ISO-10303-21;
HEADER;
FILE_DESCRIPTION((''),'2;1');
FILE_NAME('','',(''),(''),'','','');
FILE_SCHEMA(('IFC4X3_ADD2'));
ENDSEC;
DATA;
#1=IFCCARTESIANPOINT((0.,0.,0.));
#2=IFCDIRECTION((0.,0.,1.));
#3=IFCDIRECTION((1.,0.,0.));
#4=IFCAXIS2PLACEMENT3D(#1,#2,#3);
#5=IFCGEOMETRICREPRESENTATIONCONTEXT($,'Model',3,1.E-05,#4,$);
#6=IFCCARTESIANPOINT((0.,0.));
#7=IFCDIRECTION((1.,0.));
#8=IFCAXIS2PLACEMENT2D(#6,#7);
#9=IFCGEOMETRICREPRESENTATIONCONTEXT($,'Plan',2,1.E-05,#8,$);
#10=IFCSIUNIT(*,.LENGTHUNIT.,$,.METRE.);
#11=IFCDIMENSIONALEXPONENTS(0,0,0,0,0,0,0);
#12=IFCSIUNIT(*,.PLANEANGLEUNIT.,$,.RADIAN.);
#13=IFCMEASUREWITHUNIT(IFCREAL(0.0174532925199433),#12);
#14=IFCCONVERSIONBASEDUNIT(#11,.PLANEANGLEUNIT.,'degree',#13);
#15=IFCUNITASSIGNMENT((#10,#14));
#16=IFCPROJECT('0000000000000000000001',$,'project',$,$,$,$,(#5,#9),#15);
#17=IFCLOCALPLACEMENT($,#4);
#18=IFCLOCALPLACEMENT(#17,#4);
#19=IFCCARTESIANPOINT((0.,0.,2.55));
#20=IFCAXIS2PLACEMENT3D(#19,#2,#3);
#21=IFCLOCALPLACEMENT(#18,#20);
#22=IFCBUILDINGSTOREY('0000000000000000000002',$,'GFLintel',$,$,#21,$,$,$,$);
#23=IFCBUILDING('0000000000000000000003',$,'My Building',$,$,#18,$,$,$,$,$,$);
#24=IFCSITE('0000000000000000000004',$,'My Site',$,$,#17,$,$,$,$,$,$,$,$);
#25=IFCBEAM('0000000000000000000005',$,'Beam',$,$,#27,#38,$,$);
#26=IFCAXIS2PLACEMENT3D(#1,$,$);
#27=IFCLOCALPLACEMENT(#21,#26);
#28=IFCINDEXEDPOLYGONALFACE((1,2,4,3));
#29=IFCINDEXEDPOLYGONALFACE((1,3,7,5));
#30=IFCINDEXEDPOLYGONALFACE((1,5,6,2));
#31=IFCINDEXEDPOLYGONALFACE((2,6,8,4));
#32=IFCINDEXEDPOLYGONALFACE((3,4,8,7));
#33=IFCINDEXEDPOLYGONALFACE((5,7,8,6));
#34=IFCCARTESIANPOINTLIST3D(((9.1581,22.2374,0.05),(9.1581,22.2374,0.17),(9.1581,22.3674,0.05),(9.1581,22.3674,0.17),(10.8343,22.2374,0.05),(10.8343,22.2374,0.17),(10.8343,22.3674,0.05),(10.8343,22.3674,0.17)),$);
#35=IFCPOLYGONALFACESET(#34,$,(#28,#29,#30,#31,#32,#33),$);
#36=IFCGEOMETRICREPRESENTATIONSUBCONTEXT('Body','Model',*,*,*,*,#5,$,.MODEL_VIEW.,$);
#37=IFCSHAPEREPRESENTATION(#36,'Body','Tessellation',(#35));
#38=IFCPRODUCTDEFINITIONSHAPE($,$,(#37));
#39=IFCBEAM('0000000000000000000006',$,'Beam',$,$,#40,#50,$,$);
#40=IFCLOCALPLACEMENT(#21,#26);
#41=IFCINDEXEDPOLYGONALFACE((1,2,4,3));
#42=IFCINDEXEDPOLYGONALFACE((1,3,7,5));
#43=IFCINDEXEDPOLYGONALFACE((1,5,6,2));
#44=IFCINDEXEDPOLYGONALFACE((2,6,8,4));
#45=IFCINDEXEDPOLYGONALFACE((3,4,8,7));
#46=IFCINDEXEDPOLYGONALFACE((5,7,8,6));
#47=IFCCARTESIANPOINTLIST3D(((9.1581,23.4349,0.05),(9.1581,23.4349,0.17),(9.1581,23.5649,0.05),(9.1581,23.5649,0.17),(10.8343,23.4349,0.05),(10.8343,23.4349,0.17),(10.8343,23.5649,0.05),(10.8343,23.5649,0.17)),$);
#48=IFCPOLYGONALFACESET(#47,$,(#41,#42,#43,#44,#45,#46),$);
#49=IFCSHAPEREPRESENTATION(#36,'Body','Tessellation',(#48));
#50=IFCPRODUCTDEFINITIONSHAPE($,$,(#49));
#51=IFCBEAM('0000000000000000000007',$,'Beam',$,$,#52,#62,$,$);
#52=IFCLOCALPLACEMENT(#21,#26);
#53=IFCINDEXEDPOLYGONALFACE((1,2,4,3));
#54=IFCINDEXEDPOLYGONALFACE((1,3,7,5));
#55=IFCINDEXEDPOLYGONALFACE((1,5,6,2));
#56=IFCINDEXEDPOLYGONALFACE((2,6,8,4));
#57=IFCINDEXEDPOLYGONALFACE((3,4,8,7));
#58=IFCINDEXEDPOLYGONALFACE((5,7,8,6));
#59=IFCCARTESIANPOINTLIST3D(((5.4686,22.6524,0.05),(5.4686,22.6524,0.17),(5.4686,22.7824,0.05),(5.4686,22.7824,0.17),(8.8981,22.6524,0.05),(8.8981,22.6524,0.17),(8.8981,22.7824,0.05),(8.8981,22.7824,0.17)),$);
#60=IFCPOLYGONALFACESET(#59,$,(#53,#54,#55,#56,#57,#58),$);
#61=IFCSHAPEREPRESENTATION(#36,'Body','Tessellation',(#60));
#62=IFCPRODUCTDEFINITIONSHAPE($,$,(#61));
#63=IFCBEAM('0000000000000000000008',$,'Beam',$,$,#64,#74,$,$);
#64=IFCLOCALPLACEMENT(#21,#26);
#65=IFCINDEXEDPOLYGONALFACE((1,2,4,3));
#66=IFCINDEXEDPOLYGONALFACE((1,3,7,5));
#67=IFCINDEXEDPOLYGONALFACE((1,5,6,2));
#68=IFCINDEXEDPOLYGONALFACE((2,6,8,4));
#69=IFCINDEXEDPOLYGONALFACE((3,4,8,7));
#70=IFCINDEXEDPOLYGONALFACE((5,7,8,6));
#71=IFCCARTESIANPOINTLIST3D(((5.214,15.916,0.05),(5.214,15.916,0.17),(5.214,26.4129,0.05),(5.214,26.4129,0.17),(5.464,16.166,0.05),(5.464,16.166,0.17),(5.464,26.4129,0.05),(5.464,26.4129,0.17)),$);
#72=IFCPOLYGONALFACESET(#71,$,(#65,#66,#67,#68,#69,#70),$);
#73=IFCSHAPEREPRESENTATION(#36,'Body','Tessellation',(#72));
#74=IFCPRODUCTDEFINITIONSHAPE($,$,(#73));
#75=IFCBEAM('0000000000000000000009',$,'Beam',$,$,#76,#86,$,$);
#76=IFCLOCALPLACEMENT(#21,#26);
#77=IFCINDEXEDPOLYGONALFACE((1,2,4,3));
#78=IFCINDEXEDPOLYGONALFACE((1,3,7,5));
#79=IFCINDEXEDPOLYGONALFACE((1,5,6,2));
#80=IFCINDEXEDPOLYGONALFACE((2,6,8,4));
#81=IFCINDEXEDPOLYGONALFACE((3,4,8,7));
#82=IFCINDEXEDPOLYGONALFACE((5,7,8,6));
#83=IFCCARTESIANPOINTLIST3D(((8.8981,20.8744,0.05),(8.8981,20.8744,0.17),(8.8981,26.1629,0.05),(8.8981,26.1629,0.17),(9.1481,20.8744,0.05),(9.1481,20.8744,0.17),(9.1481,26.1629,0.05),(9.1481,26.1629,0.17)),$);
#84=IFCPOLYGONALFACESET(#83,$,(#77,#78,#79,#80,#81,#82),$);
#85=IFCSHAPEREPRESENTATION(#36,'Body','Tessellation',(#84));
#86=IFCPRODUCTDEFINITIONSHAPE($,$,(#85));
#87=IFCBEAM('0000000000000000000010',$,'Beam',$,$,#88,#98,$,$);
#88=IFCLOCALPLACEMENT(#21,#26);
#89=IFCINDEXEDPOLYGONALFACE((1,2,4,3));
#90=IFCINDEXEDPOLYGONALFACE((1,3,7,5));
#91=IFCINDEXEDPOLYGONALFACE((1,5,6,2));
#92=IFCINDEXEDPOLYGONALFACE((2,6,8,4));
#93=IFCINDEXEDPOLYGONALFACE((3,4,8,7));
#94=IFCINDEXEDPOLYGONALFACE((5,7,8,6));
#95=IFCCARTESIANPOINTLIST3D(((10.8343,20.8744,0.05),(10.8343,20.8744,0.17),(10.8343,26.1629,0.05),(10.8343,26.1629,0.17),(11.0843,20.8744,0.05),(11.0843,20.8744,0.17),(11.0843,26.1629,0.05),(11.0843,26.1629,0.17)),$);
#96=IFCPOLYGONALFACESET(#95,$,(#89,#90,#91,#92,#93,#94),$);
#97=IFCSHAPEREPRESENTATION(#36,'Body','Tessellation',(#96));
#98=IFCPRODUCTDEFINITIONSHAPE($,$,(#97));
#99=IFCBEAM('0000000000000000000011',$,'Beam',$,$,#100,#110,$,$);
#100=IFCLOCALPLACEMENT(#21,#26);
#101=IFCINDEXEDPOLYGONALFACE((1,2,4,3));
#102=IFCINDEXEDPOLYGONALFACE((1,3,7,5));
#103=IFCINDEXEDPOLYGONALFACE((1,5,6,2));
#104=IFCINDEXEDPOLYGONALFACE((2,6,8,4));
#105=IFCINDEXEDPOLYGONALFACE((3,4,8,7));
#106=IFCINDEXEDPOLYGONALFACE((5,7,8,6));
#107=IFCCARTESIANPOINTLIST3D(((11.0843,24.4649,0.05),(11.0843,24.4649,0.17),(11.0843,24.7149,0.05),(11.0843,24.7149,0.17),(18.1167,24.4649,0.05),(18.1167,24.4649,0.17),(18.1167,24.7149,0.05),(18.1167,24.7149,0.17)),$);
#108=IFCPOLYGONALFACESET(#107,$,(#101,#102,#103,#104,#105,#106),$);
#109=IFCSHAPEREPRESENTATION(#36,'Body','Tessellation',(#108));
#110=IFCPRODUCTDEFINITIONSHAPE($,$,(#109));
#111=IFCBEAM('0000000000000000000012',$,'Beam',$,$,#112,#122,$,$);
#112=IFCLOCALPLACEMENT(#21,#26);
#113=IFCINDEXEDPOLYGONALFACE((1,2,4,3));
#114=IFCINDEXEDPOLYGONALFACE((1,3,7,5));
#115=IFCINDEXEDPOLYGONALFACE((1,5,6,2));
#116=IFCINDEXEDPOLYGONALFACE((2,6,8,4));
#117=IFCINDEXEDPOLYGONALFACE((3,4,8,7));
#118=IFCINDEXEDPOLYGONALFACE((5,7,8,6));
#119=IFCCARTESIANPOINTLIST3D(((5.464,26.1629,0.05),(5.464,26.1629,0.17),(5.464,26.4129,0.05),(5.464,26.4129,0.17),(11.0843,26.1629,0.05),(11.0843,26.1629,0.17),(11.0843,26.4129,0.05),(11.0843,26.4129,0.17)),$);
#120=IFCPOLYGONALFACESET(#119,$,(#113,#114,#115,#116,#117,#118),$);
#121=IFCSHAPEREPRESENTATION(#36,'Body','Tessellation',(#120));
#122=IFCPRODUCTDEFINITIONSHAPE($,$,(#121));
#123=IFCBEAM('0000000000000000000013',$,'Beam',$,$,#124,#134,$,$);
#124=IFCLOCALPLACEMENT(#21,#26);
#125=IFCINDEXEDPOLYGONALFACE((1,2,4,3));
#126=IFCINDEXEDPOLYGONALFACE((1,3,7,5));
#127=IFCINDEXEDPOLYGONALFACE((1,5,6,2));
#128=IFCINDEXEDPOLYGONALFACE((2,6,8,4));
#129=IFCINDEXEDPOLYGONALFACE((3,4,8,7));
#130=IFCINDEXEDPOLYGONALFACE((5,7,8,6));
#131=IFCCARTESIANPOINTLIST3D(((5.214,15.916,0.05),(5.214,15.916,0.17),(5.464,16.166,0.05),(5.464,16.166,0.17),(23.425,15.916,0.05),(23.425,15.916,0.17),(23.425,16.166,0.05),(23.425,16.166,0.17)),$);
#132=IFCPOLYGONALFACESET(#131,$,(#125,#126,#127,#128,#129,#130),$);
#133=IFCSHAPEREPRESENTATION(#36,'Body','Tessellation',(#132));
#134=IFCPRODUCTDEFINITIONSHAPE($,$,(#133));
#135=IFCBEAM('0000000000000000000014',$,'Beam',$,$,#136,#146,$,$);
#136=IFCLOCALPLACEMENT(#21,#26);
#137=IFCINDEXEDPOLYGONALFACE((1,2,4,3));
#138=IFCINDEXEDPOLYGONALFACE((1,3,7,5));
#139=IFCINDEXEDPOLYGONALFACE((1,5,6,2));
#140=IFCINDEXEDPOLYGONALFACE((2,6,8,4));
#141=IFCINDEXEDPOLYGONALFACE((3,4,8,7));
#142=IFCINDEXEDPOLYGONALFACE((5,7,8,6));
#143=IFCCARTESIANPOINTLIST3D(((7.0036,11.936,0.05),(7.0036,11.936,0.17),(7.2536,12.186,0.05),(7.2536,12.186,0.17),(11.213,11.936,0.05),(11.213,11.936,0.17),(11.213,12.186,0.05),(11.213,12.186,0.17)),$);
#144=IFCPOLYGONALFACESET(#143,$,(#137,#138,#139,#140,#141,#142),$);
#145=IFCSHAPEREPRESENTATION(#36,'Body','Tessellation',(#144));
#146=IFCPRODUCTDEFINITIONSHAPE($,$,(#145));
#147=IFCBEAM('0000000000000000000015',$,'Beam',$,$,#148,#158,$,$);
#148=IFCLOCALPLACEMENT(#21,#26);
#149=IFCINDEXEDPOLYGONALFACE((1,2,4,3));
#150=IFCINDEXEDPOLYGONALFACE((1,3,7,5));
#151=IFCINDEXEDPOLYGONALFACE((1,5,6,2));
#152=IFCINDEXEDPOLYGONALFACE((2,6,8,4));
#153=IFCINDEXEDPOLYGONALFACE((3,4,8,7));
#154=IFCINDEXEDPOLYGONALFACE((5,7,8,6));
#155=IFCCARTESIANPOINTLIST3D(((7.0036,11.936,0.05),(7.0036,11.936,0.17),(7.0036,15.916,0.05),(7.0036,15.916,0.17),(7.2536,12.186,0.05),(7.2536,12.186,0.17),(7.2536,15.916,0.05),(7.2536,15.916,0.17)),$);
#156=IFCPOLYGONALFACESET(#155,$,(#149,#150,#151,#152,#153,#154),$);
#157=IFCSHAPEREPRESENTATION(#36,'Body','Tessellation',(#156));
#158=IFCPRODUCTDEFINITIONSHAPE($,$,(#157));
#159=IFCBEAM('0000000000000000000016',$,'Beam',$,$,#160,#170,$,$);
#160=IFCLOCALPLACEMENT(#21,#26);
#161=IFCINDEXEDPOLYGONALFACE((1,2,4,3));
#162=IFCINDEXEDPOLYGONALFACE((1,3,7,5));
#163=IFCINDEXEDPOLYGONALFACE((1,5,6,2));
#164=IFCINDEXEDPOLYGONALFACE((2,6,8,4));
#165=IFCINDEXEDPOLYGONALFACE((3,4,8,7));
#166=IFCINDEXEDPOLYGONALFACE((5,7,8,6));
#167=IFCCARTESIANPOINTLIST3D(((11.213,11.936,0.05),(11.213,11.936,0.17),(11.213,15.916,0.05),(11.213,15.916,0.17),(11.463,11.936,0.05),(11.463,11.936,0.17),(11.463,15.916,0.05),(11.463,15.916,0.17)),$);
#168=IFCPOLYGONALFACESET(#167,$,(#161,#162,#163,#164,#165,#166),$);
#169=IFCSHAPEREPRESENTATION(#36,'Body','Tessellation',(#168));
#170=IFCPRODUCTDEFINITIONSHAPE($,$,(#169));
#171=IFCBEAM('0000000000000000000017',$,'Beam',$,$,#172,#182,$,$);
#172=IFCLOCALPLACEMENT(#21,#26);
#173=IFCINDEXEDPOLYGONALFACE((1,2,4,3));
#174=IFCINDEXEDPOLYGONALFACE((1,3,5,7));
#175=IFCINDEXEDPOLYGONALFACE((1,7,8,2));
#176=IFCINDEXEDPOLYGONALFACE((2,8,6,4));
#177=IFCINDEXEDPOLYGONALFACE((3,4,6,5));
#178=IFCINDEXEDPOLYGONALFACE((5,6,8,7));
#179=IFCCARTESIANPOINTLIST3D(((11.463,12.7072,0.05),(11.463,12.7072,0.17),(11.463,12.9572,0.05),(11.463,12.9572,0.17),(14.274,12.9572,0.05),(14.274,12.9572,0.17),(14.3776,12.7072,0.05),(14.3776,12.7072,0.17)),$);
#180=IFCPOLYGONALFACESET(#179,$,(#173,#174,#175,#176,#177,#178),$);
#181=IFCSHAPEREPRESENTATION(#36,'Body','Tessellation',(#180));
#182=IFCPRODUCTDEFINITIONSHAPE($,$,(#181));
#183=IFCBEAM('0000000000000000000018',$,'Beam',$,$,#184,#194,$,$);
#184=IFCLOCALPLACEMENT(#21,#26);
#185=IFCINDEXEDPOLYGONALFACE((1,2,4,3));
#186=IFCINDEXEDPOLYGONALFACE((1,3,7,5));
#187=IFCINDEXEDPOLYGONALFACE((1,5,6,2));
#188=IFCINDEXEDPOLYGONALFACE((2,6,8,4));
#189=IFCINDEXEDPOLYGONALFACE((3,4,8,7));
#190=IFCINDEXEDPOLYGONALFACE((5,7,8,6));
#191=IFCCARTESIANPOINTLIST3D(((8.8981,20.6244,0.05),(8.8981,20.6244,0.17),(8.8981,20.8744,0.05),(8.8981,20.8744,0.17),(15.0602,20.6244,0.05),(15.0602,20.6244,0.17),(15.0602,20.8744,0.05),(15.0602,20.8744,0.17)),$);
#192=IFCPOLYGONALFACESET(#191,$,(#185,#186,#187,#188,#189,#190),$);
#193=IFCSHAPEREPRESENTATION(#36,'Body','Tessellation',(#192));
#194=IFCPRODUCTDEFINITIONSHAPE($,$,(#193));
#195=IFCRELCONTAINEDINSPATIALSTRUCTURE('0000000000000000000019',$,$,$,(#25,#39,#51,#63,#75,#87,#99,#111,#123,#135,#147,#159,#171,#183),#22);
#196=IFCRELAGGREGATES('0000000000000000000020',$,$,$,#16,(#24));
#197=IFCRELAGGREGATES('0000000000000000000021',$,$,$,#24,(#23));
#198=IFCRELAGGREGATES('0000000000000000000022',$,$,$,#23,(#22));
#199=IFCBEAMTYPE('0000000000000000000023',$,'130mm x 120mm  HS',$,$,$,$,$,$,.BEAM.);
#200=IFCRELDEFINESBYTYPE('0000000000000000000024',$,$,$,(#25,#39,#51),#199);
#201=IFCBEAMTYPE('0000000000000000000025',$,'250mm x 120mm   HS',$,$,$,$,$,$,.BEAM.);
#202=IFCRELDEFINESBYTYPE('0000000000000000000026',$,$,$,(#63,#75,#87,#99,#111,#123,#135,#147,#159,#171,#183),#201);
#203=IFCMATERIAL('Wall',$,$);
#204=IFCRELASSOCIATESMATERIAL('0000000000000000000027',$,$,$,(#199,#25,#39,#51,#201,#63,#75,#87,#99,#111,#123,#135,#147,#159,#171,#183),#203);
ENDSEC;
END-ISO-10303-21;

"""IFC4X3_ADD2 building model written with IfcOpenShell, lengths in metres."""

from ifc_helpers import new_model, entity, si_unit, converted_unit, frame, origin_with_axes, origin_2d_with_axis, place, context, subcontext, project, spatial, rectangle, extrude, clip, halfspace, material, material_profile, profile_set, profile_usage, type_object, element, save


model = new_model("IFC4X3_ADD2")

# Units and contexts
model_context = context("Model", 3, precision=1e-05, world=origin_with_axes())
plan_context = context("Plan", 2, precision=1e-05, world=origin_2d_with_axis())
body_context = subcontext(model_context, "Body", "Model", "MODEL_VIEW")
ifc_project = project(units=[si_unit("LENGTHUNIT", "METRE"), converted_unit("PLANEANGLEUNIT", "degree", entity("IfcReal", 0.0174532925199433), si_unit("PLANEANGLEUNIT", "RADIAN"), dimensions=[0, 0, 0, 0, 0, 0, 0])], contexts=[model_context, plan_context])

# Site, building, storey
site_placement = place(None, origin_with_axes())
site = spatial("IfcSite", under=ifc_project, at=site_placement, Name="My Site")
building_placement = place(site_placement, origin_with_axes())
building = spatial("IfcBuilding", under=site, at=building_placement, Name="My Building")
storey_placement = place(building_placement, frame((0.0, 0.0, 2.55), z_axis=(0.0, 0.0, 1.0), x_axis=(1.0, 0.0, 0.0)))
storey = spatial("IfcBuildingStorey", under=building, at=storey_placement, Name="GFLintel")

# Beams
ifc_material_1 = material(Name="Wall")
ifc_material_profile_1 = material_profile(ifc_material_1, rectangle(XDim=0.13, YDim=0.12))
ifc_profile_set_1 = profile_set([ifc_material_profile_1], Name="concrete")
ifc_profile_usage_1 = profile_usage(ifc_profile_set_1)
beam_type_1 = type_object("IfcBeamType", Name="130mm x 120mm  HS", PredefinedType="BEAM", material=ifc_profile_set_1)
beam_1_placement = place(storey_placement, frame((10.8343, 22.3024, 0.11), z_axis=(-1.0, 0.0, 0.0), x_axis=(0.0, -1.0, 0.0)))
element("IfcBeam", 1, at=beam_1_placement, inside=storey, type_object=beam_type_1, material=ifc_profile_usage_1, Name="Beam", context=body_context, shape_type="SweptSolid", body=[
    extrude(rectangle(XDim=0.13, YDim=0.12), origin_with_axes(), (0.0, 0.0, 1.0), 1.6762),
])
ifc_profile_usage_2 = profile_usage(ifc_profile_set_1)
beam_2_placement = place(storey_placement, frame((10.8343, 23.4999, 0.11), z_axis=(-1.0, 0.0, 0.0), x_axis=(0.0, -1.0, 0.0)))
element("IfcBeam", 2, at=beam_2_placement, inside=storey, type_object=beam_type_1, material=ifc_profile_usage_2, Name="Beam", context=body_context, shape_type="SweptSolid", body=[
    extrude(rectangle(XDim=0.13, YDim=0.12), origin_with_axes(), (0.0, 0.0, 1.0), 1.6762),
])
ifc_profile_usage_3 = profile_usage(ifc_profile_set_1)
beam_3_placement = place(storey_placement, frame((8.8981, 22.7174, 0.11), z_axis=(-1.0, 0.0, 0.0), x_axis=(0.0, -1.0, 0.0)))
element("IfcBeam", 3, at=beam_3_placement, inside=storey, type_object=beam_type_1, material=ifc_profile_usage_3, Name="Beam", context=body_context, shape_type="SweptSolid", body=[
    extrude(rectangle(XDim=0.13, YDim=0.12), origin_with_axes(), (0.0, 0.0, 1.0), 3.4295),
])
ifc_material_profile_2 = material_profile(ifc_material_1, rectangle(XDim=0.25, YDim=0.12))
ifc_profile_set_2 = profile_set([ifc_material_profile_2], Name="concrete")
ifc_profile_usage_4 = profile_usage(ifc_profile_set_2, cardinal=5)
beam_type_2 = type_object("IfcBeamType", Name="250mm x 120mm   HS", PredefinedType="BEAM", material=ifc_profile_set_2)
beam_4_placement = place(storey_placement, frame((5.339, 26.4129, 0.11), z_axis=(0.0, -1.0, 0.0), x_axis=(1.0, 0.0, 0.0)))
element("IfcBeam", 4, at=beam_4_placement, inside=storey, type_object=beam_type_2, material=ifc_profile_usage_4, Name="Beam", context=body_context, shape_type="Clipping", body=[
    clip(extrude(rectangle(XDim=0.25, YDim=0.12), origin_with_axes(), (0.0, 0.0, 1.0), 10.4969), halfspace(frame((-0.125, -2.66, 10.4969), z_axis=(0.707107, 0.0, 0.707107), x_axis=(0.0, -1.0, 0.0)), False)),
])
ifc_profile_usage_5 = profile_usage(ifc_profile_set_2, cardinal=5)
beam_5_placement = place(storey_placement, frame((9.0231, 26.1629, 0.11), z_axis=(0.0, -1.0, 0.0), x_axis=(1.0, 0.0, 0.0)))
element("IfcBeam", 5, at=beam_5_placement, inside=storey, type_object=beam_type_2, material=ifc_profile_usage_5, Name="Beam", context=body_context, shape_type="SweptSolid", body=[
    extrude(rectangle(XDim=0.25, YDim=0.12), origin_with_axes(), (0.0, 0.0, 1.0), 5.2885),
])
ifc_profile_usage_6 = profile_usage(ifc_profile_set_2, cardinal=5)
beam_6_placement = place(storey_placement, frame((10.9593, 26.1629, 0.11), z_axis=(0.0, -1.0, 0.0), x_axis=(1.0, 0.0, 0.0)))
element("IfcBeam", 6, at=beam_6_placement, inside=storey, type_object=beam_type_2, material=ifc_profile_usage_6, Name="Beam", context=body_context, shape_type="SweptSolid", body=[
    extrude(rectangle(XDim=0.25, YDim=0.12), origin_with_axes(), (0.0, 0.0, 1.0), 5.2885),
])
ifc_profile_usage_7 = profile_usage(ifc_profile_set_2, cardinal=5)
beam_7_placement = place(storey_placement, frame((11.0843, 24.5899, 0.11), z_axis=(1.0, 0.0, 0.0), x_axis=(0.0, 1.0, 0.0)))
element("IfcBeam", 7, at=beam_7_placement, inside=storey, type_object=beam_type_2, material=ifc_profile_usage_7, Name="Beam", context=body_context, shape_type="SweptSolid", body=[
    extrude(rectangle(XDim=0.25, YDim=0.12), origin_with_axes(), (0.0, 0.0, 1.0), 7.0324),
])
ifc_profile_usage_8 = profile_usage(ifc_profile_set_2, cardinal=5)
beam_8_placement = place(storey_placement, frame((5.464, 26.2879, 0.11), z_axis=(1.0, 0.0, 0.0), x_axis=(0.0, 1.0, 0.0)))
element("IfcBeam", 8, at=beam_8_placement, inside=storey, type_object=beam_type_2, material=ifc_profile_usage_8, Name="Beam", context=body_context, shape_type="SweptSolid", body=[
    extrude(rectangle(XDim=0.25, YDim=0.12), origin_with_axes(), (0.0, 0.0, 1.0), 5.6203),
])
ifc_profile_usage_9 = profile_usage(ifc_profile_set_2, cardinal=5)
beam_9_placement = place(storey_placement, frame((5.214, 16.041, 0.11), z_axis=(1.0, 0.0, 0.0), x_axis=(0.0, 1.0, 0.0)))
element("IfcBeam", 9, at=beam_9_placement, inside=storey, type_object=beam_type_2, material=ifc_profile_usage_9, Name="Beam", context=body_context, shape_type="Clipping", body=[
    clip(extrude(rectangle(XDim=0.25, YDim=0.12), origin_with_axes(), (0.0, 0.0, 1.0), 18.211), halfspace(frame((-0.125, -2.66, 0.0), z_axis=(0.707107, 0.0, -0.707107), x_axis=(0.0, -1.0, 0.0)), False)),
])
ifc_profile_usage_10 = profile_usage(ifc_profile_set_2, cardinal=5)
beam_10_placement = place(storey_placement, frame((7.0036, 12.061, 0.11), z_axis=(1.0, 0.0, 0.0), x_axis=(0.0, 1.0, 0.0)))
element("IfcBeam", 10, at=beam_10_placement, inside=storey, type_object=beam_type_2, material=ifc_profile_usage_10, Name="Beam", context=body_context, shape_type="Clipping", body=[
    clip(extrude(rectangle(XDim=0.25, YDim=0.12), origin_with_axes(), (0.0, 0.0, 1.0), 4.2094), halfspace(frame((-0.125, -2.66, 0.0), z_axis=(0.707107, 0.0, -0.707107), x_axis=(0.0, -1.0, 0.0)), False)),
])
ifc_profile_usage_11 = profile_usage(ifc_profile_set_2, cardinal=5)
beam_11_placement = place(storey_placement, frame((7.1286, 15.916, 0.11), z_axis=(0.0, -1.0, 0.0), x_axis=(1.0, 0.0, 0.0)))
element("IfcBeam", 11, at=beam_11_placement, inside=storey, type_object=beam_type_2, material=ifc_profile_usage_11, Name="Beam", context=body_context, shape_type="Clipping", body=[
    clip(extrude(rectangle(XDim=0.25, YDim=0.12), origin_with_axes(), (0.0, 0.0, 1.0), 3.98), halfspace(frame((-0.125, -2.66, 3.98), z_axis=(0.707107, 0.0, 0.707107), x_axis=(0.0, -1.0, 0.0)), False)),
])
ifc_profile_usage_12 = profile_usage(ifc_profile_set_2, cardinal=5)
beam_12_placement = place(storey_placement, frame((11.338, 15.916, 0.11), z_axis=(0.0, -1.0, 0.0), x_axis=(1.0, 0.0, 0.0)))
element("IfcBeam", 12, at=beam_12_placement, inside=storey, type_object=beam_type_2, material=ifc_profile_usage_12, Name="Beam", context=body_context, shape_type="SweptSolid", body=[
    extrude(rectangle(XDim=0.25, YDim=0.12), origin_with_axes(), (0.0, 0.0, 1.0), 3.98),
])
ifc_profile_usage_13 = profile_usage(ifc_profile_set_2, cardinal=5)
beam_13_placement = place(storey_placement, frame((11.463, 12.8322, 0.11), z_axis=(1.0, 0.0, 0.0), x_axis=(0.0, 1.0, 0.0)))
element("IfcBeam", 13, at=beam_13_placement, inside=storey, type_object=beam_type_2, material=ifc_profile_usage_13, Name="Beam", context=body_context, shape_type="Clipping", body=[
    clip(extrude(rectangle(XDim=0.25, YDim=0.12), origin_with_axes(), (0.0, 0.0, 1.0), 3.2896), halfspace(frame((-0.125, -2.66, 2.9146), z_axis=(0.382685, 0.0, 0.923879), x_axis=(0.0, -1.0, 0.0)), False)),
])
ifc_profile_usage_14 = profile_usage(ifc_profile_set_2, cardinal=5)
beam_14_placement = place(storey_placement, frame((8.8981, 20.7494, 0.11), z_axis=(1.0, 0.0, 0.0), x_axis=(0.0, 1.0, 0.0)))
element("IfcBeam", 14, at=beam_14_placement, inside=storey, type_object=beam_type_2, material=ifc_profile_usage_14, Name="Beam", context=body_context, shape_type="SweptSolid", body=[
    extrude(rectangle(XDim=0.25, YDim=0.12), origin_with_axes(), (0.0, 0.0, 1.0), 6.1621),
])

save(model, "model.ifc")
